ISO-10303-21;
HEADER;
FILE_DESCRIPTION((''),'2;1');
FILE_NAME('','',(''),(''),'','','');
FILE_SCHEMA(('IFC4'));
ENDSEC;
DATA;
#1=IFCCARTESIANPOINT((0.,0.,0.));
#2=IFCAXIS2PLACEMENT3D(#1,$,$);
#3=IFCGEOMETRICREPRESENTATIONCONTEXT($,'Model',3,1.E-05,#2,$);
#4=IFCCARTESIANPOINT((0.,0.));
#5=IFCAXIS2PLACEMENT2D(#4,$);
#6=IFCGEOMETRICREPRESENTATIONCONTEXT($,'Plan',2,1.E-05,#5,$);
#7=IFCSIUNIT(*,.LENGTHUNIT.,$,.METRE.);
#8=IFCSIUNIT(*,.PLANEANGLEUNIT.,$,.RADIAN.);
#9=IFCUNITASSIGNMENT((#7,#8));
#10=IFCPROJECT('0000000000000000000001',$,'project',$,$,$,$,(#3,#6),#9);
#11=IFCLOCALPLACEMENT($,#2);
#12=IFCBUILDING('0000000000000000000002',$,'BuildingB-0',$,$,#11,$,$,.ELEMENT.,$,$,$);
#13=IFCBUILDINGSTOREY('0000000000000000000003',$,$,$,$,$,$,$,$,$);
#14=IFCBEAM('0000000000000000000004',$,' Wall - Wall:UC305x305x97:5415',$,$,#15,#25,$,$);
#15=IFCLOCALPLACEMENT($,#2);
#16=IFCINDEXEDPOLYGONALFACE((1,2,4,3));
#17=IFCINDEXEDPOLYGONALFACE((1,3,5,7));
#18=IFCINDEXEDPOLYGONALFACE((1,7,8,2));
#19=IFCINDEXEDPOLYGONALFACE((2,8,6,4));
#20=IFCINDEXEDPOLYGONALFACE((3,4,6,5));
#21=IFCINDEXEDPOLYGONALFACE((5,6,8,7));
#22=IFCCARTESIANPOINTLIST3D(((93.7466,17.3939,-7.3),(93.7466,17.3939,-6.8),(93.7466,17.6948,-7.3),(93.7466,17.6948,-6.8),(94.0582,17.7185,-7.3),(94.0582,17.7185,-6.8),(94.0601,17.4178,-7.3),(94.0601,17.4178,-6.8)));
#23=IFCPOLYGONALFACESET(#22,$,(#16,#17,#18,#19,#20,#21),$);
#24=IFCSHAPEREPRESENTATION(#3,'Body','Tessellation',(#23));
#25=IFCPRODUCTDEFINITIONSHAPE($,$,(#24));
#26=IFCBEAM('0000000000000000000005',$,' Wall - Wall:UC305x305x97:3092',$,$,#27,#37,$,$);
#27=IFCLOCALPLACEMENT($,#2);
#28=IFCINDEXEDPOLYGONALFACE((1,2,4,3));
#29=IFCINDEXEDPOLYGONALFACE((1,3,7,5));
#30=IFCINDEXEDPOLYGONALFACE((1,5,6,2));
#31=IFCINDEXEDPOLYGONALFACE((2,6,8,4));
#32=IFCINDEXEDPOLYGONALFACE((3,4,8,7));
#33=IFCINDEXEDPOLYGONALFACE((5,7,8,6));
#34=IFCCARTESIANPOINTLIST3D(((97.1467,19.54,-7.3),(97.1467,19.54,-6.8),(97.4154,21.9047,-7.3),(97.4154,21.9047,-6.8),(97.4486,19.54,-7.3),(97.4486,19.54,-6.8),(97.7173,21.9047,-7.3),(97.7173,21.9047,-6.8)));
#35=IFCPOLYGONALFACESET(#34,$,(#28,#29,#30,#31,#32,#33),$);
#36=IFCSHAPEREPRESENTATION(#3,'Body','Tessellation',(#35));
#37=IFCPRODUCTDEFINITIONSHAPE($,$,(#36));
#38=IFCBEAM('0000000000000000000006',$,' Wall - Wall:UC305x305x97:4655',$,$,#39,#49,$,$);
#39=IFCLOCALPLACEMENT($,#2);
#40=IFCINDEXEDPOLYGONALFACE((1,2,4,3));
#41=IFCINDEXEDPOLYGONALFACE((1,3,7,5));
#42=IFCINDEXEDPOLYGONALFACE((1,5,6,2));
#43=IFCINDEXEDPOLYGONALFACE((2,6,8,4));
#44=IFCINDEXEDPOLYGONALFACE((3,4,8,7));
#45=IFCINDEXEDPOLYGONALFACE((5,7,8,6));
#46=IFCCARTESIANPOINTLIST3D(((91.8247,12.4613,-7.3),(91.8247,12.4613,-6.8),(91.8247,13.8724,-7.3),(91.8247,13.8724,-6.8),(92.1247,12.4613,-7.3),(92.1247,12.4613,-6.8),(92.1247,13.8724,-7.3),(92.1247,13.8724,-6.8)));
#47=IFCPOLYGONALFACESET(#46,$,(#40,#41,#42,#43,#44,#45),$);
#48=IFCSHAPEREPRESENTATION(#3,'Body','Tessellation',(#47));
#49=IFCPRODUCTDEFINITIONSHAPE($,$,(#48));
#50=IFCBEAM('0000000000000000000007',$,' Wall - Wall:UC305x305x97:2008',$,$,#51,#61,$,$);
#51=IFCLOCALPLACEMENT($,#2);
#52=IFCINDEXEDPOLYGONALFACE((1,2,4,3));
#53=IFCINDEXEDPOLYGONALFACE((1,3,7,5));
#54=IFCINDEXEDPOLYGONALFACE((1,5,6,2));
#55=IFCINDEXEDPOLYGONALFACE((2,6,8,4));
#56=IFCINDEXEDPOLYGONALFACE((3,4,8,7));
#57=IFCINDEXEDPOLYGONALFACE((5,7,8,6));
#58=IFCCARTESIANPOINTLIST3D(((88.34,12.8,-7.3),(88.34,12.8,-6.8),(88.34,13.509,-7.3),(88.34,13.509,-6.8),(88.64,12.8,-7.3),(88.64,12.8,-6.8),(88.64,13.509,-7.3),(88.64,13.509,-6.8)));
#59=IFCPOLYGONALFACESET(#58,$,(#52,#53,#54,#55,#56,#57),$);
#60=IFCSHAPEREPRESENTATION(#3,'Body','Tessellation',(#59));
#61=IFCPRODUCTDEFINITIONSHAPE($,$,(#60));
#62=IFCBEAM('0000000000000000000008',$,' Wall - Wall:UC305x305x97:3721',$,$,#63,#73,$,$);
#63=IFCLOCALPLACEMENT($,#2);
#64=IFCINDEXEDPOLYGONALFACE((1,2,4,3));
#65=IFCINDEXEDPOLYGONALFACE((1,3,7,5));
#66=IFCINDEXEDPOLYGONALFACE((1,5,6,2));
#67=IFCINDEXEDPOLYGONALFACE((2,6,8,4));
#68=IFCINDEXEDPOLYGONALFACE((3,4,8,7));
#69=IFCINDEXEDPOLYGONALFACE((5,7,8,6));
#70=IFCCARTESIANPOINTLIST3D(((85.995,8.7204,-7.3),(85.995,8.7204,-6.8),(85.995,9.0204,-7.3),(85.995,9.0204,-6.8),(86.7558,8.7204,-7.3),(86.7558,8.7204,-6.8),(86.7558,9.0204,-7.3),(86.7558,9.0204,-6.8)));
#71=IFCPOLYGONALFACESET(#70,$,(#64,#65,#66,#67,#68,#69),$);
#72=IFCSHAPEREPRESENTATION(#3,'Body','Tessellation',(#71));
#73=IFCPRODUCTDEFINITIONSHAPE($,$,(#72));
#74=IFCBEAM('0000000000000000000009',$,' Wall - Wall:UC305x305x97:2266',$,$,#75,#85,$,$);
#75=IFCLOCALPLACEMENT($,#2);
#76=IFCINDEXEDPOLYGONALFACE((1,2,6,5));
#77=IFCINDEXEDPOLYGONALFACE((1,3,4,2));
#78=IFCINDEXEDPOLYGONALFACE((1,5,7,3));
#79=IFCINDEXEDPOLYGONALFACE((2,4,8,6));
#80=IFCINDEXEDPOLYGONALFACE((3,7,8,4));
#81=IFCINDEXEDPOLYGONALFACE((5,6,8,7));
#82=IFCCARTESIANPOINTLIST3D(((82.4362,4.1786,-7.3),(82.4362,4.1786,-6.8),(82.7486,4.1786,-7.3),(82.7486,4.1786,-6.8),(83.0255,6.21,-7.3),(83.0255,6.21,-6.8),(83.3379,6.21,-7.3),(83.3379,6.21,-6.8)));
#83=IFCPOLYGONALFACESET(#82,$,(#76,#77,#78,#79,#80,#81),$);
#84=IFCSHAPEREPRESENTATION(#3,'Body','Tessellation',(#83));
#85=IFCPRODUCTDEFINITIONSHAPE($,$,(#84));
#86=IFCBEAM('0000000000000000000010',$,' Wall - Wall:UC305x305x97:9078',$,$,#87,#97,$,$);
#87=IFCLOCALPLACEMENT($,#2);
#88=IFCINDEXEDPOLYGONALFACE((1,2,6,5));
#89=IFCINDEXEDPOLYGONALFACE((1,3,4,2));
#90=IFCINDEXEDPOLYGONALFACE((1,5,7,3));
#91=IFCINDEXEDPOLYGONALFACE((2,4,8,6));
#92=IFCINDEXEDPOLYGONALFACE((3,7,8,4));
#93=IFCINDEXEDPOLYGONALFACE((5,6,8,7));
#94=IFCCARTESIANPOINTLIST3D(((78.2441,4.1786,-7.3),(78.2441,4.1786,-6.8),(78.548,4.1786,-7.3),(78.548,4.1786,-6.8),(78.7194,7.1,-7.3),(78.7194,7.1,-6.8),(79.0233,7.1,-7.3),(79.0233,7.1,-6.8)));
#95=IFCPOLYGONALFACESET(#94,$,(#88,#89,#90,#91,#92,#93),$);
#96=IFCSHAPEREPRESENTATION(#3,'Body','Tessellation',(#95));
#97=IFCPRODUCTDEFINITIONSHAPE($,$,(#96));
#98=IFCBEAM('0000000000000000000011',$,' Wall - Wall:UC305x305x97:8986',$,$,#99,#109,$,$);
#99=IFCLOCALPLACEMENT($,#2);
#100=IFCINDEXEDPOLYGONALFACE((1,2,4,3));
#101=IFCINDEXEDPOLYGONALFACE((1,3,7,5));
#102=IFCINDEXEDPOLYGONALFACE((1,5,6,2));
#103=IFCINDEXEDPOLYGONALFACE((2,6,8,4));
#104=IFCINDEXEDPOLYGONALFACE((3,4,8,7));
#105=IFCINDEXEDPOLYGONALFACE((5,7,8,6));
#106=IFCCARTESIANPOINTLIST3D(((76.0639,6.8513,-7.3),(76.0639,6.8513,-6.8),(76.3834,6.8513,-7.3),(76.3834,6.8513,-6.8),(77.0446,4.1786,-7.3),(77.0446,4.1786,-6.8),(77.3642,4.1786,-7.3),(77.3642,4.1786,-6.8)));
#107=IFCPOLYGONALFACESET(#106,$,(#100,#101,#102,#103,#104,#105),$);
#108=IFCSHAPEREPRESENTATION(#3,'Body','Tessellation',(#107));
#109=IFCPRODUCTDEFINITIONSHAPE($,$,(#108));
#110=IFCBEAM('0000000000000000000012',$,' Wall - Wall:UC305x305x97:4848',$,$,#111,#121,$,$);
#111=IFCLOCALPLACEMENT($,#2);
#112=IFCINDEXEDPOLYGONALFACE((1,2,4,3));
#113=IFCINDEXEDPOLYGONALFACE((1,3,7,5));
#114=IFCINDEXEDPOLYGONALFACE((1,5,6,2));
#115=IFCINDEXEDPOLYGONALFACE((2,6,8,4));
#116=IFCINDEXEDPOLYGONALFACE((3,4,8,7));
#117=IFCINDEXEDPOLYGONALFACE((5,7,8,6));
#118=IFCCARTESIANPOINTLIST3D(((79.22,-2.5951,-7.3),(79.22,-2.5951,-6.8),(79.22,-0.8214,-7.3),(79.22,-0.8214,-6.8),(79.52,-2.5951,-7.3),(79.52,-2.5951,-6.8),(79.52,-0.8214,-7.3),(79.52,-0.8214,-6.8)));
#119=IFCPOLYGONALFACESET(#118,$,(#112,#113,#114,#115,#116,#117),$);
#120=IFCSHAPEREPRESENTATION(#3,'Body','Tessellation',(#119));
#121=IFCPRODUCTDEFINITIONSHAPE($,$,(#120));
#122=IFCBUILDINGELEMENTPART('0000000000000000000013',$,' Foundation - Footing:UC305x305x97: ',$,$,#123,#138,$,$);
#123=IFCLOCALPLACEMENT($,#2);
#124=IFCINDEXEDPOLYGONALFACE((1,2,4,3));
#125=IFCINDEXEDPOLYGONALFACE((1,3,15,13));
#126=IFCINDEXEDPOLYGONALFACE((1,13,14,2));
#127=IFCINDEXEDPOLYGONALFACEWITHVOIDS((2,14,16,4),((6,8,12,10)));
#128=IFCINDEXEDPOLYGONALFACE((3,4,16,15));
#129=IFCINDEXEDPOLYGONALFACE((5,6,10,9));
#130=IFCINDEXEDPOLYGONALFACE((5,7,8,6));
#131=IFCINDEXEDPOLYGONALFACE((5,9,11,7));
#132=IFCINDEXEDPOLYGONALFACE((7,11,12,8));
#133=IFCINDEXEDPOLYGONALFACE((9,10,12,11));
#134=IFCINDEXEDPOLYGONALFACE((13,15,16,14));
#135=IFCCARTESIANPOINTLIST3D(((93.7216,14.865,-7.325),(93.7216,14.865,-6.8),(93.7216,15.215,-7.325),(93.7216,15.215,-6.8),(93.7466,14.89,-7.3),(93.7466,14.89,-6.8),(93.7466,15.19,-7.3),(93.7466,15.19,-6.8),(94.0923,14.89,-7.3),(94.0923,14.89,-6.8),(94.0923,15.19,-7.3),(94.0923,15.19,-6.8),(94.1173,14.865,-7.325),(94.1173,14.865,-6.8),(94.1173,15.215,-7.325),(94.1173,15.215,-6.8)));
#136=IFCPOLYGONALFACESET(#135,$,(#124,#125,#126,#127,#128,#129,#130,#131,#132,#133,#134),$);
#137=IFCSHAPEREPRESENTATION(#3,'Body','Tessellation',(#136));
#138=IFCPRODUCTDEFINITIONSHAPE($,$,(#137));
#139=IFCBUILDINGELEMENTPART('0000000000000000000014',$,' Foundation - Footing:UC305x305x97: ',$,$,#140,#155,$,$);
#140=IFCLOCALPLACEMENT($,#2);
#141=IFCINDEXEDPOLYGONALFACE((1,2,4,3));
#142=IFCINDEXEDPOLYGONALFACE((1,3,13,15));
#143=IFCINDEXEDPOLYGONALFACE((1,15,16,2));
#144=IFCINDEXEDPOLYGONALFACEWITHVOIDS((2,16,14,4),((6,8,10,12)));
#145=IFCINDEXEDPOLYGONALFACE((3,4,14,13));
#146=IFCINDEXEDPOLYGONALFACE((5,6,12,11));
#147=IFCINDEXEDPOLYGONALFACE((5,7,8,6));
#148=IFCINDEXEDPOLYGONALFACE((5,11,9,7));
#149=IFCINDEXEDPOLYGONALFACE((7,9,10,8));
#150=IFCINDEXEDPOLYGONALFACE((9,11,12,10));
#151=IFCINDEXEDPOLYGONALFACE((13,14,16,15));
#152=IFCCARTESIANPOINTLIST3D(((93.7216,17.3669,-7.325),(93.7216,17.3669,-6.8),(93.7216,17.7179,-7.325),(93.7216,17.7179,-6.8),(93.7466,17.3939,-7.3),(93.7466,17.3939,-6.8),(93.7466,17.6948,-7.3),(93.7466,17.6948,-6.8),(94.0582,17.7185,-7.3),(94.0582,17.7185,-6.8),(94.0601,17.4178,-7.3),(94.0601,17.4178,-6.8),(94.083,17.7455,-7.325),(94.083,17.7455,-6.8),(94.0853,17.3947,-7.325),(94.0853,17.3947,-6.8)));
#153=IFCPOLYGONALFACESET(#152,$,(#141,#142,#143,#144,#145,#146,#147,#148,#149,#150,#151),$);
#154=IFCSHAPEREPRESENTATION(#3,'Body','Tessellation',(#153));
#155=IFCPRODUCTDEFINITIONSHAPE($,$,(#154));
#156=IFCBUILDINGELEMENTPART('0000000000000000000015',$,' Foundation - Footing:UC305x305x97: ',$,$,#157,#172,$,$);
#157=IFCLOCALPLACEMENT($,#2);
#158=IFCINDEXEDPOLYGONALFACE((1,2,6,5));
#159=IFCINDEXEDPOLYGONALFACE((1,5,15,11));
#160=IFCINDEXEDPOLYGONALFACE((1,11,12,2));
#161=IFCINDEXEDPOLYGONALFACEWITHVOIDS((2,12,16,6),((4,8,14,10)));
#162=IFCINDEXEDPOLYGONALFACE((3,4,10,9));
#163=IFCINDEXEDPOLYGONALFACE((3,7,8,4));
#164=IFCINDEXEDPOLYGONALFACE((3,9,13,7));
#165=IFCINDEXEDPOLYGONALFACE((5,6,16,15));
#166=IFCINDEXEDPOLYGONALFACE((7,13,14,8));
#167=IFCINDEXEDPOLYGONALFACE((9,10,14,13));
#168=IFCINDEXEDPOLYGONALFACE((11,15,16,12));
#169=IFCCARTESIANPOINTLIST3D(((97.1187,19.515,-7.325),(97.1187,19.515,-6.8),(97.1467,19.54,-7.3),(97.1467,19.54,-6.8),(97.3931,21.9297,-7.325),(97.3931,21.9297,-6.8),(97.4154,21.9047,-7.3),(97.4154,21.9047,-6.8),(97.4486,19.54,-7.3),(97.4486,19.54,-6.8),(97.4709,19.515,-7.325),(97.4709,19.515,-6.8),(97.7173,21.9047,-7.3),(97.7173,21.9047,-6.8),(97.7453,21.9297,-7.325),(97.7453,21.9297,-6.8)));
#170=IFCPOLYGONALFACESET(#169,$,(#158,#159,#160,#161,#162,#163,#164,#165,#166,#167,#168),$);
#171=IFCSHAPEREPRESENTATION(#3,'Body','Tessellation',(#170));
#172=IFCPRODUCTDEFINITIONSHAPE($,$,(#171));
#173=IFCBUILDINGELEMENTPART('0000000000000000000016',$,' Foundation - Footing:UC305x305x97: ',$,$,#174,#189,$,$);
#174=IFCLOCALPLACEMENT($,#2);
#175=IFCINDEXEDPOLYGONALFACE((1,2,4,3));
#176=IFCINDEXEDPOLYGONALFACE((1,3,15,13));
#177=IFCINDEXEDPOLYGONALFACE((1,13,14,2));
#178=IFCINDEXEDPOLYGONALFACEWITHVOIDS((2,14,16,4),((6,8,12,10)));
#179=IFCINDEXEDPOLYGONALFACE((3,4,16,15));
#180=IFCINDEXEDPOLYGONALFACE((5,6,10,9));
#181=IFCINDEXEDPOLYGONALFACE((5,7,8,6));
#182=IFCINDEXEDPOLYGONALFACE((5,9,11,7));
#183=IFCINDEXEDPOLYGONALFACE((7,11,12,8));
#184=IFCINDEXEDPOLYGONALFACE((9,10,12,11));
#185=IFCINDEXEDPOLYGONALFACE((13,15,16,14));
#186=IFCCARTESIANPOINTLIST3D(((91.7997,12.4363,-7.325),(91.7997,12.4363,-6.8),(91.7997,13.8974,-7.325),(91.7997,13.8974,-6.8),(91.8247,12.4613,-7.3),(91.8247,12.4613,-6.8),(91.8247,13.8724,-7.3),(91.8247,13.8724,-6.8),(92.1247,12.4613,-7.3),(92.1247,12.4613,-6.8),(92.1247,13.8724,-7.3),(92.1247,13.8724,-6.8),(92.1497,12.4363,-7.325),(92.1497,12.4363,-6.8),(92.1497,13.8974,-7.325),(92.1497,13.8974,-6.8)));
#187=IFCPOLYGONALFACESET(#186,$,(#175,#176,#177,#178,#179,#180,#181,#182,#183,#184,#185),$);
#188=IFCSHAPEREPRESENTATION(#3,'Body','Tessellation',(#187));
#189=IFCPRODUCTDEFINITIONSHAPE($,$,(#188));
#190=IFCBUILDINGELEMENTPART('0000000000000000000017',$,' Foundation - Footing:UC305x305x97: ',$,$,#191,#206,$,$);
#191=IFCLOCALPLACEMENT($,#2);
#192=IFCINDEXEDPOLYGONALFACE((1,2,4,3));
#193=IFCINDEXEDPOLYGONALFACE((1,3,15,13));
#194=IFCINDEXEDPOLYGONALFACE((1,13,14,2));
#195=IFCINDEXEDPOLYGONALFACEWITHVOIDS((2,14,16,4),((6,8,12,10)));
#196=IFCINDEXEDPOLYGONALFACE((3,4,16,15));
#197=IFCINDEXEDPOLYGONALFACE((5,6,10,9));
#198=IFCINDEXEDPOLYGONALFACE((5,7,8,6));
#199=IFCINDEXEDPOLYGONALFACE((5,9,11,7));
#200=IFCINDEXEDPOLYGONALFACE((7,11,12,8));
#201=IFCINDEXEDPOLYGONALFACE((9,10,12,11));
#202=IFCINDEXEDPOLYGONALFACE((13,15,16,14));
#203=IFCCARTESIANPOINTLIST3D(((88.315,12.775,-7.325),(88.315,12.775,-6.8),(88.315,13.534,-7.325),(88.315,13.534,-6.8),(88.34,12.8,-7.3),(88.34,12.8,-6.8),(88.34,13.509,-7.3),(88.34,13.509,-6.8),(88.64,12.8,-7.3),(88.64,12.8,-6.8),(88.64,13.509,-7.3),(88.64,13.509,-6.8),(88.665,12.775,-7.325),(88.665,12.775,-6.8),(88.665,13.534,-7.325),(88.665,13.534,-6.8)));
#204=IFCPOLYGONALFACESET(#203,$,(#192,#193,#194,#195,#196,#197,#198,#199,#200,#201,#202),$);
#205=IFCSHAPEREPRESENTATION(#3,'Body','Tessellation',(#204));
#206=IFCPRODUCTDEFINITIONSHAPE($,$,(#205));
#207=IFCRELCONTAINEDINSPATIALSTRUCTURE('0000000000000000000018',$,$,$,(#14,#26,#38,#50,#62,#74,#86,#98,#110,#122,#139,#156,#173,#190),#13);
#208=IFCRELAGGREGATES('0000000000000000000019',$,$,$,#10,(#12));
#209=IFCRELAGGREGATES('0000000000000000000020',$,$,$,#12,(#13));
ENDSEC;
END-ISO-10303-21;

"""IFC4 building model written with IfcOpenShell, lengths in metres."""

from ifc_helpers import new_model, si_unit, origin, origin_2d, place, context, project, spatial, polyline, outline, extrude, element, save


model = new_model("IFC4")

# Units and contexts
model_context = context("Model", 3, precision=1e-05, world=origin())
plan_context = context("Plan", 2, precision=1e-05, world=origin_2d())
ifc_project = project(units=[si_unit("LENGTHUNIT", "METRE"), si_unit("PLANEANGLEUNIT", "RADIAN")], contexts=[model_context, plan_context])

# Building, storey
building_placement = place(None, origin())
building = spatial("IfcBuilding", under=ifc_project, at=building_placement, Name="BuildingB-0", CompositionType="ELEMENT")
storey = spatial("IfcBuildingStorey", under=building)

# Beams
element("IfcBeam", 1, inside=storey, Name=" Wall - Wall:UC305x305x97:5415", context=model_context, shape_type="SweptSolid", body=[
    extrude(outline(polyline([(94.0601, 17.4178, -7.3), (93.7466, 17.3939, -7.3), (93.7466, 17.6948, -7.3), (94.0582, 17.7185, -7.3), (94.0601, 17.4178, -7.3)])), None, (0.0, 0.0, 1.0), 0.5),
])
element("IfcBeam", 2, inside=storey, Name=" Wall - Wall:UC305x305x97:3092", context=model_context, shape_type="SweptSolid", body=[
    extrude(outline(polyline([(97.4486, 19.54, -7.3), (97.1467, 19.54, -7.3), (97.4154, 21.9047, -7.3), (97.7173, 21.9047, -7.3), (97.4486, 19.54, -7.3)])), None, (0.0, 0.0, 1.0), 0.5),
])
element("IfcBeam", 3, inside=storey, Name=" Wall - Wall:UC305x305x97:4655", context=model_context, shape_type="SweptSolid", body=[
    extrude(outline(polyline([(92.1247, 12.4613, -7.3), (91.8247, 12.4613, -7.3), (91.8247, 13.8724, -7.3), (92.1247, 13.8724, -7.3), (92.1247, 12.4613, -7.3)])), None, (0.0, 0.0, 1.0), 0.5),
])
element("IfcBeam", 4, inside=storey, Name=" Wall - Wall:UC305x305x97:2008", context=model_context, shape_type="SweptSolid", body=[
    extrude(outline(polyline([(88.64, 12.8, -7.3), (88.34, 12.8, -7.3), (88.34, 13.509, -7.3), (88.64, 13.509, -7.3), (88.64, 12.8, -7.3)])), None, (0.0, 0.0, 1.0), 0.5),
])
element("IfcBeam", 5, inside=storey, Name=" Wall - Wall:UC305x305x97:3721", context=model_context, shape_type="SweptSolid", body=[
    extrude(outline(polyline([(86.7558, 8.7204, -7.3), (85.995, 8.7204, -7.3), (85.995, 9.0204, -7.3), (86.7558, 9.0204, -7.3), (86.7558, 8.7204, -7.3)])), None, (0.0, 0.0, 1.0), 0.5),
])
element("IfcBeam", 6, inside=storey, Name=" Wall - Wall:UC305x305x97:2266", context=model_context, shape_type="SweptSolid", body=[
    extrude(outline(polyline([(82.7486, 4.1786, -7.3), (82.4362, 4.1786, -7.3), (83.0255, 6.21, -7.3), (83.3379, 6.21, -7.3), (82.7486, 4.1786, -7.3)])), None, (0.0, 0.0, 1.0), 0.5),
])
element("IfcBeam", 7, inside=storey, Name=" Wall - Wall:UC305x305x97:9078", context=model_context, shape_type="SweptSolid", body=[
    extrude(outline(polyline([(78.548, 4.1786, -7.3), (78.2441, 4.1786, -7.3), (78.7194, 7.1, -7.3), (79.0233, 7.1, -7.3), (78.548, 4.1786, -7.3)])), None, (0.0, 0.0, 1.0), 0.5),
])
element("IfcBeam", 8, inside=storey, Name=" Wall - Wall:UC305x305x97:8986", context=model_context, shape_type="SweptSolid", body=[
    extrude(outline(polyline([(77.3642, 4.1786, -7.3), (77.0446, 4.1786, -7.3), (76.0639, 6.8513, -7.3), (76.3834, 6.8513, -7.3), (77.3642, 4.1786, -7.3)])), None, (0.0, 0.0, 1.0), 0.5),
])
element("IfcBeam", 9, inside=storey, Name=" Wall - Wall:UC305x305x97:4848", context=model_context, shape_type="SweptSolid", body=[
    extrude(outline(polyline([(79.52, -2.5951, -7.3), (79.22, -2.5951, -7.3), (79.22, -0.8214, -7.3), (79.52, -0.8214, -7.3), (79.52, -2.5951, -7.3)])), None, (0.0, 0.0, 1.0), 0.5),
])

# Building element parts, openings
building_element_part_1 = element("IfcBuildingElementPart", 10, inside=storey, Name=" Foundation - Footing:UC305x305x97: ", context=model_context, shape_type="SweptSolid", body=[
    extrude(outline(polyline([(94.1173, 15.215, -7.325), (93.7216, 15.215, -7.325), (93.7216, 14.865, -7.325), (94.1173, 14.865, -7.325), (94.1173, 15.215, -7.325)])), None, (0.0, 0.0, 1.0), 0.525),
])
element("IfcOpeningElement", 11, inside=storey, cuts=building_element_part_1, context=model_context, shape_type="SweptSolid", body=[
    extrude(outline(polyline([(94.0923, 15.19, -7.3), (93.7466, 15.19, -7.3), (93.7466, 14.89, -7.3), (94.0923, 14.89, -7.3), (94.0923, 15.19, -7.3)])), None, (0.0, 0.0, 1.0), 0.5),
])
building_element_part_2 = element("IfcBuildingElementPart", 12, inside=storey, Name=" Foundation - Footing:UC305x305x97: ", context=model_context, shape_type="SweptSolid", body=[
    extrude(outline(polyline([(94.0853, 17.3947, -7.325), (93.7216, 17.3669, -7.325), (93.7216, 17.7179, -7.325), (94.083, 17.7455, -7.325), (94.0853, 17.3947, -7.325)])), None, (0.0, 0.0, 1.0), 0.525),
])
element("IfcOpeningElement", 13, inside=storey, cuts=building_element_part_2, context=model_context, shape_type="SweptSolid", body=[
    extrude(outline(polyline([(94.0601, 17.4178, -7.3), (93.7466, 17.3939, -7.3), (93.7466, 17.6948, -7.3), (94.0582, 17.7185, -7.3), (94.0601, 17.4178, -7.3)])), None, (0.0, 0.0, 1.0), 0.5),
])
building_element_part_3 = element("IfcBuildingElementPart", 14, inside=storey, Name=" Foundation - Footing:UC305x305x97: ", context=model_context, shape_type="SweptSolid", body=[
    extrude(outline(polyline([(97.4709, 19.515, -7.325), (97.1187, 19.515, -7.325), (97.3931, 21.9297, -7.325), (97.7453, 21.9297, -7.325), (97.4709, 19.515, -7.325)])), None, (0.0, 0.0, 1.0), 0.525),
])
element("IfcOpeningElement", 15, inside=storey, cuts=building_element_part_3, context=model_context, shape_type="SweptSolid", body=[
    extrude(outline(polyline([(97.4486, 19.54, -7.3), (97.1467, 19.54, -7.3), (97.4154, 21.9047, -7.3), (97.7173, 21.9047, -7.3), (97.4486, 19.54, -7.3)])), None, (0.0, 0.0, 1.0), 0.5),
])
building_element_part_4 = element("IfcBuildingElementPart", 16, inside=storey, Name=" Foundation - Footing:UC305x305x97: ", context=model_context, shape_type="SweptSolid", body=[
    extrude(outline(polyline([(92.1497, 12.4363, -7.325), (91.7997, 12.4363, -7.325), (91.7997, 13.8974, -7.325), (92.1497, 13.8974, -7.325), (92.1497, 12.4363, -7.325)])), None, (0.0, 0.0, 1.0), 0.525),
])
element("IfcOpeningElement", 17, inside=storey, cuts=building_element_part_4, context=model_context, shape_type="SweptSolid", body=[
    extrude(outline(polyline([(92.1247, 12.4613, -7.3), (91.8247, 12.4613, -7.3), (91.8247, 13.8724, -7.3), (92.1247, 13.8724, -7.3), (92.1247, 12.4613, -7.3)])), None, (0.0, 0.0, 1.0), 0.5),
])
building_element_part_5 = element("IfcBuildingElementPart", 18, inside=storey, Name=" Foundation - Footing:UC305x305x97: ", context=model_context, shape_type="SweptSolid", body=[
    extrude(outline(polyline([(88.665, 12.775, -7.325), (88.315, 12.775, -7.325), (88.315, 13.534, -7.325), (88.665, 13.534, -7.325), (88.665, 12.775, -7.325)])), None, (0.0, 0.0, 1.0), 0.525),
])
element("IfcOpeningElement", 19, inside=storey, cuts=building_element_part_5, context=model_context, shape_type="SweptSolid", body=[
    extrude(outline(polyline([(88.64, 12.8, -7.3), (88.34, 12.8, -7.3), (88.34, 13.509, -7.3), (88.64, 13.509, -7.3), (88.64, 12.8, -7.3)])), None, (0.0, 0.0, 1.0), 0.5),
])

save(model, "model.ifc")
